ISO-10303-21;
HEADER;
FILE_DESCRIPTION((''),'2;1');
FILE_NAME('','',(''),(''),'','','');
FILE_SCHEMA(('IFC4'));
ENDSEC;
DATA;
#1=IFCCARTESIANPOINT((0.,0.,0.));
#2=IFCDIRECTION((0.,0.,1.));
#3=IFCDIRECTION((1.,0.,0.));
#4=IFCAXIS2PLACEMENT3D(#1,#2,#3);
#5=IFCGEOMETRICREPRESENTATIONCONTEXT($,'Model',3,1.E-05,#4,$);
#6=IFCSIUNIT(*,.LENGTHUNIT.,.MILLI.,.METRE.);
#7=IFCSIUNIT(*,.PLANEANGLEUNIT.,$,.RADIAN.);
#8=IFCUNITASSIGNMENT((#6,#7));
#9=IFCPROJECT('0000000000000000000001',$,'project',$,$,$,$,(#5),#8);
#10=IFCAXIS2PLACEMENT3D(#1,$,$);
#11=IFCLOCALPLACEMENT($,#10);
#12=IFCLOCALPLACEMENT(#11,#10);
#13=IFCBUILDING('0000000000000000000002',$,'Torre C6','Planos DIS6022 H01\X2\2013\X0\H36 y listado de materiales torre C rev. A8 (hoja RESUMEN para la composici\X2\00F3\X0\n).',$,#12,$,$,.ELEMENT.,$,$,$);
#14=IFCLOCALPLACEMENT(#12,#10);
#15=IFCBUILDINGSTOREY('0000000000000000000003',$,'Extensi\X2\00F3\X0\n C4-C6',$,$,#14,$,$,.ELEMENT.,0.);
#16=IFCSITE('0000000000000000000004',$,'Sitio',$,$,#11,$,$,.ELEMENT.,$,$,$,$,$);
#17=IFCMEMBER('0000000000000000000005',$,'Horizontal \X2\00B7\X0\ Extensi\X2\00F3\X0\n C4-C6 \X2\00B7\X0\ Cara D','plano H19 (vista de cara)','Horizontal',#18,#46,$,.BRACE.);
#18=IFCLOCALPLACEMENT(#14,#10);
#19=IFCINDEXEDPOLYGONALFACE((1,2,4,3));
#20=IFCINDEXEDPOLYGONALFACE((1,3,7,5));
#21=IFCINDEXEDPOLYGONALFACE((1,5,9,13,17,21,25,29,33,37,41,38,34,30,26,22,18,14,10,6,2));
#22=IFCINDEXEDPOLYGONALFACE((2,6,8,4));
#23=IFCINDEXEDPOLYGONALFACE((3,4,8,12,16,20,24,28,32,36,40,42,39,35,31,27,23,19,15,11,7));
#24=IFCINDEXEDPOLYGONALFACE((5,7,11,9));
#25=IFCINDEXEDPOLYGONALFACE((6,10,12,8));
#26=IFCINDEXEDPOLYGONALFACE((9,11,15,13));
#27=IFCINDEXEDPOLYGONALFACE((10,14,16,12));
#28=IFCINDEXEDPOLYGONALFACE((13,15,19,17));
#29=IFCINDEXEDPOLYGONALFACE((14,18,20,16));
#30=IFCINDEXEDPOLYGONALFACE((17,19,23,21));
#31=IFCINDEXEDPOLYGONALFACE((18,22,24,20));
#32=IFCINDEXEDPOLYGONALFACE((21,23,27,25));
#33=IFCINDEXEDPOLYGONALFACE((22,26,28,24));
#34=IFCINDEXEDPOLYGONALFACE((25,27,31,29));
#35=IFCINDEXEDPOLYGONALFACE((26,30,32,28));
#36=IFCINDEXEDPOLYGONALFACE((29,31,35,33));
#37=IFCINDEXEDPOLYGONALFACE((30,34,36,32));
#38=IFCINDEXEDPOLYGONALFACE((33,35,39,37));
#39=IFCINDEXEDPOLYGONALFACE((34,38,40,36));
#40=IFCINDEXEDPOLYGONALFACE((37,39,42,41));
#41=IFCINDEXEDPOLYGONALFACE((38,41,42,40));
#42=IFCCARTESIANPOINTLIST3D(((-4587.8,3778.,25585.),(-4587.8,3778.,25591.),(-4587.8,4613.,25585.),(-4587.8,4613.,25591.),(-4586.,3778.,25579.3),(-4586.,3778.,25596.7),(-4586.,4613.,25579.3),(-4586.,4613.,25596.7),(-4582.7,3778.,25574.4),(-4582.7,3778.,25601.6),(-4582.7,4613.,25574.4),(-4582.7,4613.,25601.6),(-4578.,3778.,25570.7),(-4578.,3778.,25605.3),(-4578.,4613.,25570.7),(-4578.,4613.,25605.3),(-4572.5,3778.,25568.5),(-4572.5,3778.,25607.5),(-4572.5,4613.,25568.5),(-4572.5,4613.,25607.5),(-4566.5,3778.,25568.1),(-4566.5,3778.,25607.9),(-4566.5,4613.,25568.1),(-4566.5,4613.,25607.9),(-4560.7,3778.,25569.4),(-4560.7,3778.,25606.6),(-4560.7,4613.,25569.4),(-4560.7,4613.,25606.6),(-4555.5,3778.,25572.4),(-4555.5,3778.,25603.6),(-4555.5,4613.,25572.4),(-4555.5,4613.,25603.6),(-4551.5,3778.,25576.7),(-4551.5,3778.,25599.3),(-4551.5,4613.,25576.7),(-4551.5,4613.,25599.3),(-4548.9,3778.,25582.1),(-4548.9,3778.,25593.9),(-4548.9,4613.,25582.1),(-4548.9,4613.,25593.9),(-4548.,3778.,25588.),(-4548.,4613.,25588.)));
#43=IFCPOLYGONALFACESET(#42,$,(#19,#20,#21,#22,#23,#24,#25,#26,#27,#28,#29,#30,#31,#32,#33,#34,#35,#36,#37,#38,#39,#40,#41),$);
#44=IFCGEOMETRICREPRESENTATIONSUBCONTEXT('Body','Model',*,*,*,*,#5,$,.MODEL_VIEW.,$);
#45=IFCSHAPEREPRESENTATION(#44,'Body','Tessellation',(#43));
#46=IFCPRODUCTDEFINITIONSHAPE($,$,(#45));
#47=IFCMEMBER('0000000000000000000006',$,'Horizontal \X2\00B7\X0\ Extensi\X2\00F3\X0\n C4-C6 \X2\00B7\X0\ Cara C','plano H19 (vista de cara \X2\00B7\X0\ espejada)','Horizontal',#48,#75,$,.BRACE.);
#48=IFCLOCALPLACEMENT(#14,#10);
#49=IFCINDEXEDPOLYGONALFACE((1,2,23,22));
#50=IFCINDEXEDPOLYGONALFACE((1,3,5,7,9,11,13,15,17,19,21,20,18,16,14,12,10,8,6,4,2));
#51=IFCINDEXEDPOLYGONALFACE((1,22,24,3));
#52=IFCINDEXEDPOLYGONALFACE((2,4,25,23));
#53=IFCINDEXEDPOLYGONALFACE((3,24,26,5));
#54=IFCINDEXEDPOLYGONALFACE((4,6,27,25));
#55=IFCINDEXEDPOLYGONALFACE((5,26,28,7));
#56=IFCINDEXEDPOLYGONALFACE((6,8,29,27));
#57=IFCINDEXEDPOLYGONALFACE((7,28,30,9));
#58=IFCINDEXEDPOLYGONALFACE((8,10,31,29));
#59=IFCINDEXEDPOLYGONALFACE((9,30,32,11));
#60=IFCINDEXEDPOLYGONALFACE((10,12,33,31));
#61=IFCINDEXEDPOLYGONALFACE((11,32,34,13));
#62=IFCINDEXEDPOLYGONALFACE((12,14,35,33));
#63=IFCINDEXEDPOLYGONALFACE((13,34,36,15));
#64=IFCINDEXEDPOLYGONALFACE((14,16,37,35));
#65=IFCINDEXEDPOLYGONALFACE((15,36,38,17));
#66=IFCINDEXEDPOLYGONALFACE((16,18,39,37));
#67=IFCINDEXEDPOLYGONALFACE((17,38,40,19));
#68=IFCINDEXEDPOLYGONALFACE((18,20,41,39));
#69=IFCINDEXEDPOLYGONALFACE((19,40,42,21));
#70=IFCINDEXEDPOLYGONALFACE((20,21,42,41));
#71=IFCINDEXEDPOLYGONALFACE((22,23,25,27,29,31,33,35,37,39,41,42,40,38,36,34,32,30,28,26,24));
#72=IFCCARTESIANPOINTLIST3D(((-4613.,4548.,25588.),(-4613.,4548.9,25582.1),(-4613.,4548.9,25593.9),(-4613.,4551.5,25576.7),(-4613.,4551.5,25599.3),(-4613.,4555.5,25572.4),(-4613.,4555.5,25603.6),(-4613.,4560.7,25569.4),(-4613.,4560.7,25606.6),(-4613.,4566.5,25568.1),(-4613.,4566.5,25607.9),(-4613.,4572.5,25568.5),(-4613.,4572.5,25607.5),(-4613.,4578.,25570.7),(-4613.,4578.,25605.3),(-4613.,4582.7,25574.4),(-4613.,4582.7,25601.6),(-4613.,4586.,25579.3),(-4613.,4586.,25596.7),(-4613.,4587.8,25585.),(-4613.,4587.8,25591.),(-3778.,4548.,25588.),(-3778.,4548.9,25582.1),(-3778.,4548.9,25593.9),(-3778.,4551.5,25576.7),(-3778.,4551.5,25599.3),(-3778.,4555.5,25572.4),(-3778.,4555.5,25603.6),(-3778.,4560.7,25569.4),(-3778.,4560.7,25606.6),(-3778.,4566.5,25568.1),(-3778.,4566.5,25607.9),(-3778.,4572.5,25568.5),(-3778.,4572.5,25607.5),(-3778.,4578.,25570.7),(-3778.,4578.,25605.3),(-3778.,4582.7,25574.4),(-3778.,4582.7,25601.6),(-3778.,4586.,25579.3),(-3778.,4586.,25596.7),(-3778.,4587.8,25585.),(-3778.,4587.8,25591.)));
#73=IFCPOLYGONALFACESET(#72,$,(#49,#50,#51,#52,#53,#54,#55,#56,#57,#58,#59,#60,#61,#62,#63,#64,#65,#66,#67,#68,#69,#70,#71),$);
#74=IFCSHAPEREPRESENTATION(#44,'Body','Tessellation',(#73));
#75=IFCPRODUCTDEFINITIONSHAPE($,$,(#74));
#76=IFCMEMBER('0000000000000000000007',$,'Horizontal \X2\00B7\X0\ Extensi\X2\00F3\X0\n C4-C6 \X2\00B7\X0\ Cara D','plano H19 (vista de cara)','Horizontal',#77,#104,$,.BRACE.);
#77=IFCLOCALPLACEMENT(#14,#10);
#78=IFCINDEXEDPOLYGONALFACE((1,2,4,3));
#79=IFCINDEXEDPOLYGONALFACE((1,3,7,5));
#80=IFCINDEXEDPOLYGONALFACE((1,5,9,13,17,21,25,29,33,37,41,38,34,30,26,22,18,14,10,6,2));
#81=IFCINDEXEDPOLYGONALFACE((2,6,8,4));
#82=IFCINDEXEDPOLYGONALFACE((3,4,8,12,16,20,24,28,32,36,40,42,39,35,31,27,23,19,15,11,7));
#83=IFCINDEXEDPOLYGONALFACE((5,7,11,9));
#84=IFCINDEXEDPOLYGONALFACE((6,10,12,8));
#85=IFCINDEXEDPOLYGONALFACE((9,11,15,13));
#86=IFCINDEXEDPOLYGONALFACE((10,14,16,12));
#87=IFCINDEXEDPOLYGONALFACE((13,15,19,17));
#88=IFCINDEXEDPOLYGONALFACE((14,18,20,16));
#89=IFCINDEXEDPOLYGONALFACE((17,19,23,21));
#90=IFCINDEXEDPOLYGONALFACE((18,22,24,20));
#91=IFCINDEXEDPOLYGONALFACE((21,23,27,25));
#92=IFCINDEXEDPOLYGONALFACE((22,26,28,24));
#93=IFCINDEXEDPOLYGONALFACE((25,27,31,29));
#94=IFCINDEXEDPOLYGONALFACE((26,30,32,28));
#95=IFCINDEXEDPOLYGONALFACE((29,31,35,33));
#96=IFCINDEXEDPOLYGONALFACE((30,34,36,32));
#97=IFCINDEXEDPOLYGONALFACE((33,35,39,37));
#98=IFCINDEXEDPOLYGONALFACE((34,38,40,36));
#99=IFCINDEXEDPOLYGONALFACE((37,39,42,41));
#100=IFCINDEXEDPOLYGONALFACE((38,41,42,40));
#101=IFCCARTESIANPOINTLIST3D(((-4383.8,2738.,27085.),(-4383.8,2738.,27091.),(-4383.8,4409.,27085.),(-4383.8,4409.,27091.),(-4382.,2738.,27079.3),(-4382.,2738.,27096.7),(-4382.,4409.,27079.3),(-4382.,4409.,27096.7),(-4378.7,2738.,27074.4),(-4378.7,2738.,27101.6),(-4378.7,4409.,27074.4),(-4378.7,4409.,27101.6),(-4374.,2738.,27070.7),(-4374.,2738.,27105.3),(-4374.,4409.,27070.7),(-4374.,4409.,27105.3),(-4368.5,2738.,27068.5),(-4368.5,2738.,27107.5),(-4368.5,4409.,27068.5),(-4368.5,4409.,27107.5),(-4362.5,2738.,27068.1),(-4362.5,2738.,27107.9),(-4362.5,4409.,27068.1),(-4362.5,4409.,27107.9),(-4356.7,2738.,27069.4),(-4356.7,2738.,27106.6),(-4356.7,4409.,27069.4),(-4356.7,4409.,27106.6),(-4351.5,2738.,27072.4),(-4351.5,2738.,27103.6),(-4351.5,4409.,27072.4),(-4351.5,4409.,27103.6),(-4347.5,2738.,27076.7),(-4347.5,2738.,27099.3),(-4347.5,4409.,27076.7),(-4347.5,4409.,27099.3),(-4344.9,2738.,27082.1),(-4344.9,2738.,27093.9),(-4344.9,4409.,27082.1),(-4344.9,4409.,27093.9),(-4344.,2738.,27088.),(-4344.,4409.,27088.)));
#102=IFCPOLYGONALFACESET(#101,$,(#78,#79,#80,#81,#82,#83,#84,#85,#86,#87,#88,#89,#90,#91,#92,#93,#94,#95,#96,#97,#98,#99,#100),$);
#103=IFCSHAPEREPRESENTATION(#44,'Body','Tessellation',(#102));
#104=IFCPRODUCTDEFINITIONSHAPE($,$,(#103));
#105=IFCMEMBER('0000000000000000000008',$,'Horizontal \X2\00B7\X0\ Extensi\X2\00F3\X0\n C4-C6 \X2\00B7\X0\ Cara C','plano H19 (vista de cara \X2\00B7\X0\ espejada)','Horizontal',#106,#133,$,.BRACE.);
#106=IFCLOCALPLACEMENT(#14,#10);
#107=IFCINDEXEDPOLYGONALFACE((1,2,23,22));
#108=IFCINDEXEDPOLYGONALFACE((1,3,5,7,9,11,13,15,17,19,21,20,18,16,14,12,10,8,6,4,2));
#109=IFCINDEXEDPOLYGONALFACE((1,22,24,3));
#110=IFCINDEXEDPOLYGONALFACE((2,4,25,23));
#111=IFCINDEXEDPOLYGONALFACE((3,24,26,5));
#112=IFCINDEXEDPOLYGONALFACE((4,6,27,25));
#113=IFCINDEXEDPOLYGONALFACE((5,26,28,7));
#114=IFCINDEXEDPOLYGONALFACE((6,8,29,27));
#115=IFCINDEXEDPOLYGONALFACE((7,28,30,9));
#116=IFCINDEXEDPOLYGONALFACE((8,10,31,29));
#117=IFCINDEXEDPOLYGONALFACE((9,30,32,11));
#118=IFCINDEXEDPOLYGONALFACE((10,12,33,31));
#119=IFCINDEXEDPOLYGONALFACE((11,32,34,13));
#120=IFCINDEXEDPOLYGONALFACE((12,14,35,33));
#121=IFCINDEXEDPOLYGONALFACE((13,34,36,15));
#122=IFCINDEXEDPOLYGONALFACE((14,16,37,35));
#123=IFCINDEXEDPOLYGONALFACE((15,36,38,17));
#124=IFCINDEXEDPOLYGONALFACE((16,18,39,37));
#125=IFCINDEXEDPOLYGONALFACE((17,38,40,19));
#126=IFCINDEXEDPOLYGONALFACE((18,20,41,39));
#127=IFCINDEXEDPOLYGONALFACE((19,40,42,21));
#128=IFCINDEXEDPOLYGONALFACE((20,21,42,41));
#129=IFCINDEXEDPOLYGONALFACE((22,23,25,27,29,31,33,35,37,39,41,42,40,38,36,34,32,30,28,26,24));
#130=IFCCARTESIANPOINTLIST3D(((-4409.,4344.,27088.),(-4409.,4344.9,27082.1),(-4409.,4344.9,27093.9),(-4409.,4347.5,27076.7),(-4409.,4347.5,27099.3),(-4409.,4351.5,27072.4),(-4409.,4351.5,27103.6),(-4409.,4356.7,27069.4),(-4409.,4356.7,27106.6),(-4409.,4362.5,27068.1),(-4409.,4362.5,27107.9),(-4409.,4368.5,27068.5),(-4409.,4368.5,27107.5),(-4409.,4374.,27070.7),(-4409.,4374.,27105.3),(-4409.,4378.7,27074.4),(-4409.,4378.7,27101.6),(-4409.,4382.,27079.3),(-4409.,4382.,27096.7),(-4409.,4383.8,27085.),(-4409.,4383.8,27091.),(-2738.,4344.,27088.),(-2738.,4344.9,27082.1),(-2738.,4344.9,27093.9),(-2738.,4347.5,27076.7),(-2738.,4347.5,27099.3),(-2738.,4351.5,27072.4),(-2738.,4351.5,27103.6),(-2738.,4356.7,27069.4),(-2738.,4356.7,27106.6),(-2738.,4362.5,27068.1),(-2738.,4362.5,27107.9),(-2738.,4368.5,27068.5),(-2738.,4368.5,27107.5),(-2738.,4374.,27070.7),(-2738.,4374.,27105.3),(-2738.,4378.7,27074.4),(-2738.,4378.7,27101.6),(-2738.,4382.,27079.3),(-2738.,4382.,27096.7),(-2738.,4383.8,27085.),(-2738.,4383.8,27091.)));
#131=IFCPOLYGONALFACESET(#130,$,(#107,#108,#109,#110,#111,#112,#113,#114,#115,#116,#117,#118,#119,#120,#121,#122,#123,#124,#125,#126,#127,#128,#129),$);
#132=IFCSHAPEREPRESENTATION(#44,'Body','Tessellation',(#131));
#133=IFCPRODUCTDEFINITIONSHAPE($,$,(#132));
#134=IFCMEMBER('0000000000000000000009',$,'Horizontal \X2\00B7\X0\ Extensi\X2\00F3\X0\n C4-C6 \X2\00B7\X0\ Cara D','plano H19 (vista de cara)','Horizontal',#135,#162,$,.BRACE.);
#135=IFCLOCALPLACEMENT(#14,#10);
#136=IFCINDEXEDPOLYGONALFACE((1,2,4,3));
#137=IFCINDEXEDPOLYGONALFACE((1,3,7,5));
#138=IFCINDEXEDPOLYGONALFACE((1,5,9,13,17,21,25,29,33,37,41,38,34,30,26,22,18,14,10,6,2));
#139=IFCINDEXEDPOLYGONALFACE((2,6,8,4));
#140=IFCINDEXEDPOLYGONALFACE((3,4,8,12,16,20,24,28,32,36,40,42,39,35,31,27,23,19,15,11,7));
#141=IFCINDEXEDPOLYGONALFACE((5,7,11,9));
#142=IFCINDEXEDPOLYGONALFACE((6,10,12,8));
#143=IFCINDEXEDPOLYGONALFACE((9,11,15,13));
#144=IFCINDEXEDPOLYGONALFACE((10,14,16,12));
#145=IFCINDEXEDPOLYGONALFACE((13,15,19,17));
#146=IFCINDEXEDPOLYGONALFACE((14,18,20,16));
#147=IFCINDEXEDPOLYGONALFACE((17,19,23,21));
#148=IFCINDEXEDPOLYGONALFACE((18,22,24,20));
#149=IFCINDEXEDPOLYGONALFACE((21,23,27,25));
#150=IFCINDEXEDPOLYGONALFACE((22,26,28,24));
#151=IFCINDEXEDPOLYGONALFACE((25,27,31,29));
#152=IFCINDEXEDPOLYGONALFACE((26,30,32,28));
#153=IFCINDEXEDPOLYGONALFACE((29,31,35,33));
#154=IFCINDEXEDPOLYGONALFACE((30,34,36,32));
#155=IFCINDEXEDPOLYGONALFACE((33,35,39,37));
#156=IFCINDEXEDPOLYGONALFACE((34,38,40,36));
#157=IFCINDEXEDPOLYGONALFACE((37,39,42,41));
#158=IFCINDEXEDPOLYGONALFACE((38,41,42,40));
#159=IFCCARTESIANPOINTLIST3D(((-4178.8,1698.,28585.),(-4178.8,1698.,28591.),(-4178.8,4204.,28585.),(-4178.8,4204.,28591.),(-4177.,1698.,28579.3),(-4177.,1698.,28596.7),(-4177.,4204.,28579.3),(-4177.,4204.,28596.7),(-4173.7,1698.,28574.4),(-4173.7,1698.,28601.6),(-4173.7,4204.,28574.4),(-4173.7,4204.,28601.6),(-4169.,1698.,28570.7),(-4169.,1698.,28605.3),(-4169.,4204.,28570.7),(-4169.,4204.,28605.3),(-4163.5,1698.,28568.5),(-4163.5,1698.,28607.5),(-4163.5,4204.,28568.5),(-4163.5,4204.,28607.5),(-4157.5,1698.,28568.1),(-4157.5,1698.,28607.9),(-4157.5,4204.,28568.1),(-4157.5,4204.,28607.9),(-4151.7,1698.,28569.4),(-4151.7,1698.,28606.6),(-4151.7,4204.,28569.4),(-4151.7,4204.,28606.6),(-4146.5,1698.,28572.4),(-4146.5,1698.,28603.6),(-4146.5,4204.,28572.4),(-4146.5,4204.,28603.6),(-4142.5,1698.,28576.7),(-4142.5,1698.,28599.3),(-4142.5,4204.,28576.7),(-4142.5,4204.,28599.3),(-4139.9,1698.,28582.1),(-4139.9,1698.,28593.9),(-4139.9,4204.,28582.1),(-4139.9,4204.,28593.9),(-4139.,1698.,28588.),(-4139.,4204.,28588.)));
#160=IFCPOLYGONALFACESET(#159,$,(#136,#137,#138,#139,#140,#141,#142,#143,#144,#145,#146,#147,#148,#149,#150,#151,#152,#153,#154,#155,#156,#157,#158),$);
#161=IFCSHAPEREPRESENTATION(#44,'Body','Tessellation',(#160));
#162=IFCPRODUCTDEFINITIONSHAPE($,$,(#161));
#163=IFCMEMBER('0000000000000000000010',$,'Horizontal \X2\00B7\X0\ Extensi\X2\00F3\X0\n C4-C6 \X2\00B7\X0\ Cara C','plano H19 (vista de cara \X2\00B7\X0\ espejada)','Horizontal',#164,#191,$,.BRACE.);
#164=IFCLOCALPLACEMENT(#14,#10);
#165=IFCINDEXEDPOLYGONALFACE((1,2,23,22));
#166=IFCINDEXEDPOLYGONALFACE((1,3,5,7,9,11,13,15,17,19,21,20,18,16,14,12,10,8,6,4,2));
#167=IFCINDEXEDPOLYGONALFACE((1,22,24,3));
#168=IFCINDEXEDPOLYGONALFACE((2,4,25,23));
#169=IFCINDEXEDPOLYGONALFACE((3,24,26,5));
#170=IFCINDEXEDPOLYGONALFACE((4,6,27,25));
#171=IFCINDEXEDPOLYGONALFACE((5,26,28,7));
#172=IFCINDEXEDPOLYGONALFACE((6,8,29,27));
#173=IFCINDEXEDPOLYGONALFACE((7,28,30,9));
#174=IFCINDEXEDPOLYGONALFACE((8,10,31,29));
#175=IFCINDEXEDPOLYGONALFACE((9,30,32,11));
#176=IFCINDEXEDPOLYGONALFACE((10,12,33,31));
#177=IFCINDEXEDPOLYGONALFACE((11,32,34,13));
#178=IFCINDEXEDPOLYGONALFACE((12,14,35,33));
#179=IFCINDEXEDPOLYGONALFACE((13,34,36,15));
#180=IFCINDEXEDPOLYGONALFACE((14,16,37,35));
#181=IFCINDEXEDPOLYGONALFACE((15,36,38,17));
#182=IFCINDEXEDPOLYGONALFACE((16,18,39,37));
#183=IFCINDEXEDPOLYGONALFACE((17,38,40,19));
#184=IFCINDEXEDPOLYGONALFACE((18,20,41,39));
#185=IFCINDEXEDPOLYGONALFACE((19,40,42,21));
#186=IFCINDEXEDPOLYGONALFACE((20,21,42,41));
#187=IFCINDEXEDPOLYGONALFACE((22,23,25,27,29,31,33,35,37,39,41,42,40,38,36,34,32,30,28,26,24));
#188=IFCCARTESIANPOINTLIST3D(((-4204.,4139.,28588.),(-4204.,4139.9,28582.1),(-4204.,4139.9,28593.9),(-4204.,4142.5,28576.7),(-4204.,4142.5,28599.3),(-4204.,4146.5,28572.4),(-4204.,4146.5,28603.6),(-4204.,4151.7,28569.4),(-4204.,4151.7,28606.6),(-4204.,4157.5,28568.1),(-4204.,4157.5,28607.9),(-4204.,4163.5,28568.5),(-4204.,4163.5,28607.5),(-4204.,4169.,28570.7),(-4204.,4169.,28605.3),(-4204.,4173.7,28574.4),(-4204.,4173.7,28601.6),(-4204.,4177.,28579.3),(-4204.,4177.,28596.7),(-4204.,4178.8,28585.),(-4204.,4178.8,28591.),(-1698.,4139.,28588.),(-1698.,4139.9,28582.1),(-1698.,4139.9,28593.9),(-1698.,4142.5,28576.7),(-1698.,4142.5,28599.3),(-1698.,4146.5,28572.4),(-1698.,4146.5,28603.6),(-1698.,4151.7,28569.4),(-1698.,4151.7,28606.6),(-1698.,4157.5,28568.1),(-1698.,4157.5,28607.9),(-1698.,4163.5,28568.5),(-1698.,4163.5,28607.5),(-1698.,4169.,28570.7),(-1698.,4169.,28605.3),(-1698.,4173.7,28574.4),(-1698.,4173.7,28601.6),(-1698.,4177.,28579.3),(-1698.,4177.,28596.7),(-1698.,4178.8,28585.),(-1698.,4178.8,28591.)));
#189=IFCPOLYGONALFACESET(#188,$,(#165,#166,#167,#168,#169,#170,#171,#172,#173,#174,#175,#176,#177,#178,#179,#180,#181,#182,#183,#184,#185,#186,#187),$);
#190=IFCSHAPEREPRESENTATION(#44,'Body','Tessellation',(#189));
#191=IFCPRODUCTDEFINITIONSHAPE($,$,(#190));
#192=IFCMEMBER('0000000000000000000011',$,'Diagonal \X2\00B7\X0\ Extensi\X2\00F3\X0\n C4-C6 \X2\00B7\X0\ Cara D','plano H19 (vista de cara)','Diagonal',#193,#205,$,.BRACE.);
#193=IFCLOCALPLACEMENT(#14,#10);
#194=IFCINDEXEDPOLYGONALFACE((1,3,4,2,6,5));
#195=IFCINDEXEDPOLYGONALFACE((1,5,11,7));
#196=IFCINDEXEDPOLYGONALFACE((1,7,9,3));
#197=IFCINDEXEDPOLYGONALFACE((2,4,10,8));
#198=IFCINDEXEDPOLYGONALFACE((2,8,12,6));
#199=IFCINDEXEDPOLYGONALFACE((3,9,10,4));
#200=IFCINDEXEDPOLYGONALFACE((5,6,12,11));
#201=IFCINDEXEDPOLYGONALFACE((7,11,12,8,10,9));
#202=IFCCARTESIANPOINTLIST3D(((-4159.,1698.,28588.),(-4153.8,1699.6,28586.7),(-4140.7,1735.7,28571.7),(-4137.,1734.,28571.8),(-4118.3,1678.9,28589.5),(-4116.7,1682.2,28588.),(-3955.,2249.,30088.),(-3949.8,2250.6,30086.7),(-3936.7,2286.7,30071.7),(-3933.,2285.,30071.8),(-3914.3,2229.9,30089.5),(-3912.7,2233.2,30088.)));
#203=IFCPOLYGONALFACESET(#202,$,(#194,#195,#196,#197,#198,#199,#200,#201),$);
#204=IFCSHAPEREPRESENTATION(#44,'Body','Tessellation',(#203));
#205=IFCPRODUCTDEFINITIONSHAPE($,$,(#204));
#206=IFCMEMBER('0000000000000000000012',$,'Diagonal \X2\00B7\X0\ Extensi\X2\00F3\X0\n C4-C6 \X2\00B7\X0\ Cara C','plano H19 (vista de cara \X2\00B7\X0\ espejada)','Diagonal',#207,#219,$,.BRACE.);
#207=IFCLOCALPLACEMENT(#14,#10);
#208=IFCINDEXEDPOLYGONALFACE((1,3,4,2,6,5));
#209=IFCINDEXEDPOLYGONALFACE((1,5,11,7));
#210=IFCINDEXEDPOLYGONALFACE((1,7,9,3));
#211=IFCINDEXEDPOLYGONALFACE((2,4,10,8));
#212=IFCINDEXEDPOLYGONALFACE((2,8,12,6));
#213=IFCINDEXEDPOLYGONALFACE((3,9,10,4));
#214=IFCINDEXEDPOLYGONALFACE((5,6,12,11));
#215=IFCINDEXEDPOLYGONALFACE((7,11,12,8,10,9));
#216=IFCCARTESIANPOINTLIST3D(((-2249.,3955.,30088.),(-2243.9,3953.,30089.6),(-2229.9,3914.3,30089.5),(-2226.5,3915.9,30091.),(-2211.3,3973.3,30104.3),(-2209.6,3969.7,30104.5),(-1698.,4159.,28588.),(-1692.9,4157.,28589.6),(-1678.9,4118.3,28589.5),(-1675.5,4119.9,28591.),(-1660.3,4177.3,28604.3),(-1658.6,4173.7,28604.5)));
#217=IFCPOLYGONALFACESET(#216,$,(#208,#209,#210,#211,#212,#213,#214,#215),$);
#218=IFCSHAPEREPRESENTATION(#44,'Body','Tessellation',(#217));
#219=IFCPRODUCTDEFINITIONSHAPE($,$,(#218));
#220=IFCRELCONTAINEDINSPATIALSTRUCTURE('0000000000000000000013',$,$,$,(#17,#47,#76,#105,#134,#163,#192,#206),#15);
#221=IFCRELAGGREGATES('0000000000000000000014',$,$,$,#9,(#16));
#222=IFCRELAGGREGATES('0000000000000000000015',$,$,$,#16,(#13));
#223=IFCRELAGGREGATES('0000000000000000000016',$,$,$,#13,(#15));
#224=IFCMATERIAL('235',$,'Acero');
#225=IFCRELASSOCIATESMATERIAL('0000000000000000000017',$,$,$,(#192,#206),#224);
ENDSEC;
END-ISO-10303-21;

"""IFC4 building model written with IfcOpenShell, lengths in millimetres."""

from ifc_helpers import new_model, si_unit, frame, frame_2d, origin, origin_with_axes, place, context, subcontext, project, spatial, circle, l_section, extrude, material, element, save


model = new_model("IFC4")

# Units and contexts
model_context = context("Model", 3, precision=1e-05, world=origin_with_axes())
body_context = subcontext(model_context, "Body", "Model", "MODEL_VIEW")
ifc_project = project(units=[si_unit("LENGTHUNIT", "METRE", prefix="MILLI"), si_unit("PLANEANGLEUNIT", "RADIAN")], contexts=[model_context])

# Site, building, storey
site_placement = place(None, origin())
site = spatial("IfcSite", under=ifc_project, at=site_placement, Name="Sitio", CompositionType="ELEMENT")
building_placement = place(site_placement, origin())
building = spatial("IfcBuilding", under=site, at=building_placement, Name="Torre C6", Description="Planos DIS6022 H01–H36 y listado de materiales torre C rev. A8 (hoja RESUMEN para la composición).", CompositionType="ELEMENT")
storey_placement = place(building_placement, origin())
storey = spatial("IfcBuildingStorey", under=building, at=storey_placement, Name="Extensión C4-C6", CompositionType="ELEMENT", Elevation=0.0)

# Members
ifc_material = material(Name="235", Category="Acero")
for number, where, z_axis, x_axis, name, description in (
    (1, (-4568.0, 3778.0, 25588.0), (0.0, 1.0, 0.0), (1.0, 0.0, 0.0), "Horizontal · Extensión C4-C6 · Cara D", "plano H19 (vista de cara)"),
    (2, (-3778.0, 4568.0, 25588.0), (-1.0, 0.0, 0.0), (0.0, -1.0, 0.0), "Horizontal · Extensión C4-C6 · Cara C", "plano H19 (vista de cara · espejada)"),
):
    element("IfcMember", number, at=place(storey_placement, frame(where, z_axis=z_axis, x_axis=x_axis)), inside=storey, Name=name, Description=description, ObjectType="Horizontal", PredefinedType="BRACE", context=body_context, shape_type="SweptSolid", body=[
        extrude(circle(Radius=20.0), None, (0.0, 0.0, 1.0), 835.0),
    ])
for number, where, z_axis, x_axis, name, description in (
    (3, (-4364.0, 2738.0, 27088.0), (0.0, 1.0, 0.0), (1.0, 0.0, 0.0), "Horizontal · Extensión C4-C6 · Cara D", "plano H19 (vista de cara)"),
    (4, (-2738.0, 4364.0, 27088.0), (-1.0, 0.0, 0.0), (0.0, -1.0, 0.0), "Horizontal · Extensión C4-C6 · Cara C", "plano H19 (vista de cara · espejada)"),
):
    element("IfcMember", number, at=place(storey_placement, frame(where, z_axis=z_axis, x_axis=x_axis)), inside=storey, Name=name, Description=description, ObjectType="Horizontal", PredefinedType="BRACE", context=body_context, shape_type="SweptSolid", body=[
        extrude(circle(Radius=20.0), None, (0.0, 0.0, 1.0), 1671.0),
    ])
for number, where, z_axis, x_axis, name, description in (
    (5, (-4159.0, 1698.0, 28588.0), (0.0, 1.0, 0.0), (1.0, 0.0, 0.0), "Horizontal · Extensión C4-C6 · Cara D", "plano H19 (vista de cara)"),
    (6, (-1698.0, 4159.0, 28588.0), (-1.0, 0.0, 0.0), (0.0, -1.0, 0.0), "Horizontal · Extensión C4-C6 · Cara C", "plano H19 (vista de cara · espejada)"),
):
    element("IfcMember", number, at=place(storey_placement, frame(where, z_axis=z_axis, x_axis=x_axis)), inside=storey, Name=name, Description=description, ObjectType="Horizontal", PredefinedType="BRACE", context=body_context, shape_type="SweptSolid", body=[
        extrude(circle(Radius=20.0), None, (0.0, 0.0, 1.0), 2506.0),
    ])
for number, where, z_axis, x_axis, name, description in (
    (7, (-4159.0, 1698.0, 28588.0), (0.126632, 0.34203, 0.931117), (0.904354, -0.425481, 0.033301), "Diagonal · Extensión C4-C6 · Cara D", "plano H19 (vista de cara)"),
    (8, (-1698.0, 4159.0, 28588.0), (-0.34203, -0.126632, 0.931117), (0.425481, -0.904354, 0.033301), "Diagonal · Extensión C4-C6 · Cara C", "plano H19 (vista de cara · espejada)"),
):
    element("IfcMember", number, at=place(storey_placement, frame(where, z_axis=z_axis, x_axis=x_axis)), inside=storey, material=ifc_material, Name=name, Description=description, ObjectType="Diagonal", PredefinedType="BRACE", context=body_context, shape_type="SweptSolid", body=[
        extrude(l_section(Depth=45.0, Width=45.0, Thickness=4.0, at=frame_2d((22.5, 22.5))), None, (0.0, 0.0, 1.0), 1611.0),
    ])

save(model, "model.ifc")
